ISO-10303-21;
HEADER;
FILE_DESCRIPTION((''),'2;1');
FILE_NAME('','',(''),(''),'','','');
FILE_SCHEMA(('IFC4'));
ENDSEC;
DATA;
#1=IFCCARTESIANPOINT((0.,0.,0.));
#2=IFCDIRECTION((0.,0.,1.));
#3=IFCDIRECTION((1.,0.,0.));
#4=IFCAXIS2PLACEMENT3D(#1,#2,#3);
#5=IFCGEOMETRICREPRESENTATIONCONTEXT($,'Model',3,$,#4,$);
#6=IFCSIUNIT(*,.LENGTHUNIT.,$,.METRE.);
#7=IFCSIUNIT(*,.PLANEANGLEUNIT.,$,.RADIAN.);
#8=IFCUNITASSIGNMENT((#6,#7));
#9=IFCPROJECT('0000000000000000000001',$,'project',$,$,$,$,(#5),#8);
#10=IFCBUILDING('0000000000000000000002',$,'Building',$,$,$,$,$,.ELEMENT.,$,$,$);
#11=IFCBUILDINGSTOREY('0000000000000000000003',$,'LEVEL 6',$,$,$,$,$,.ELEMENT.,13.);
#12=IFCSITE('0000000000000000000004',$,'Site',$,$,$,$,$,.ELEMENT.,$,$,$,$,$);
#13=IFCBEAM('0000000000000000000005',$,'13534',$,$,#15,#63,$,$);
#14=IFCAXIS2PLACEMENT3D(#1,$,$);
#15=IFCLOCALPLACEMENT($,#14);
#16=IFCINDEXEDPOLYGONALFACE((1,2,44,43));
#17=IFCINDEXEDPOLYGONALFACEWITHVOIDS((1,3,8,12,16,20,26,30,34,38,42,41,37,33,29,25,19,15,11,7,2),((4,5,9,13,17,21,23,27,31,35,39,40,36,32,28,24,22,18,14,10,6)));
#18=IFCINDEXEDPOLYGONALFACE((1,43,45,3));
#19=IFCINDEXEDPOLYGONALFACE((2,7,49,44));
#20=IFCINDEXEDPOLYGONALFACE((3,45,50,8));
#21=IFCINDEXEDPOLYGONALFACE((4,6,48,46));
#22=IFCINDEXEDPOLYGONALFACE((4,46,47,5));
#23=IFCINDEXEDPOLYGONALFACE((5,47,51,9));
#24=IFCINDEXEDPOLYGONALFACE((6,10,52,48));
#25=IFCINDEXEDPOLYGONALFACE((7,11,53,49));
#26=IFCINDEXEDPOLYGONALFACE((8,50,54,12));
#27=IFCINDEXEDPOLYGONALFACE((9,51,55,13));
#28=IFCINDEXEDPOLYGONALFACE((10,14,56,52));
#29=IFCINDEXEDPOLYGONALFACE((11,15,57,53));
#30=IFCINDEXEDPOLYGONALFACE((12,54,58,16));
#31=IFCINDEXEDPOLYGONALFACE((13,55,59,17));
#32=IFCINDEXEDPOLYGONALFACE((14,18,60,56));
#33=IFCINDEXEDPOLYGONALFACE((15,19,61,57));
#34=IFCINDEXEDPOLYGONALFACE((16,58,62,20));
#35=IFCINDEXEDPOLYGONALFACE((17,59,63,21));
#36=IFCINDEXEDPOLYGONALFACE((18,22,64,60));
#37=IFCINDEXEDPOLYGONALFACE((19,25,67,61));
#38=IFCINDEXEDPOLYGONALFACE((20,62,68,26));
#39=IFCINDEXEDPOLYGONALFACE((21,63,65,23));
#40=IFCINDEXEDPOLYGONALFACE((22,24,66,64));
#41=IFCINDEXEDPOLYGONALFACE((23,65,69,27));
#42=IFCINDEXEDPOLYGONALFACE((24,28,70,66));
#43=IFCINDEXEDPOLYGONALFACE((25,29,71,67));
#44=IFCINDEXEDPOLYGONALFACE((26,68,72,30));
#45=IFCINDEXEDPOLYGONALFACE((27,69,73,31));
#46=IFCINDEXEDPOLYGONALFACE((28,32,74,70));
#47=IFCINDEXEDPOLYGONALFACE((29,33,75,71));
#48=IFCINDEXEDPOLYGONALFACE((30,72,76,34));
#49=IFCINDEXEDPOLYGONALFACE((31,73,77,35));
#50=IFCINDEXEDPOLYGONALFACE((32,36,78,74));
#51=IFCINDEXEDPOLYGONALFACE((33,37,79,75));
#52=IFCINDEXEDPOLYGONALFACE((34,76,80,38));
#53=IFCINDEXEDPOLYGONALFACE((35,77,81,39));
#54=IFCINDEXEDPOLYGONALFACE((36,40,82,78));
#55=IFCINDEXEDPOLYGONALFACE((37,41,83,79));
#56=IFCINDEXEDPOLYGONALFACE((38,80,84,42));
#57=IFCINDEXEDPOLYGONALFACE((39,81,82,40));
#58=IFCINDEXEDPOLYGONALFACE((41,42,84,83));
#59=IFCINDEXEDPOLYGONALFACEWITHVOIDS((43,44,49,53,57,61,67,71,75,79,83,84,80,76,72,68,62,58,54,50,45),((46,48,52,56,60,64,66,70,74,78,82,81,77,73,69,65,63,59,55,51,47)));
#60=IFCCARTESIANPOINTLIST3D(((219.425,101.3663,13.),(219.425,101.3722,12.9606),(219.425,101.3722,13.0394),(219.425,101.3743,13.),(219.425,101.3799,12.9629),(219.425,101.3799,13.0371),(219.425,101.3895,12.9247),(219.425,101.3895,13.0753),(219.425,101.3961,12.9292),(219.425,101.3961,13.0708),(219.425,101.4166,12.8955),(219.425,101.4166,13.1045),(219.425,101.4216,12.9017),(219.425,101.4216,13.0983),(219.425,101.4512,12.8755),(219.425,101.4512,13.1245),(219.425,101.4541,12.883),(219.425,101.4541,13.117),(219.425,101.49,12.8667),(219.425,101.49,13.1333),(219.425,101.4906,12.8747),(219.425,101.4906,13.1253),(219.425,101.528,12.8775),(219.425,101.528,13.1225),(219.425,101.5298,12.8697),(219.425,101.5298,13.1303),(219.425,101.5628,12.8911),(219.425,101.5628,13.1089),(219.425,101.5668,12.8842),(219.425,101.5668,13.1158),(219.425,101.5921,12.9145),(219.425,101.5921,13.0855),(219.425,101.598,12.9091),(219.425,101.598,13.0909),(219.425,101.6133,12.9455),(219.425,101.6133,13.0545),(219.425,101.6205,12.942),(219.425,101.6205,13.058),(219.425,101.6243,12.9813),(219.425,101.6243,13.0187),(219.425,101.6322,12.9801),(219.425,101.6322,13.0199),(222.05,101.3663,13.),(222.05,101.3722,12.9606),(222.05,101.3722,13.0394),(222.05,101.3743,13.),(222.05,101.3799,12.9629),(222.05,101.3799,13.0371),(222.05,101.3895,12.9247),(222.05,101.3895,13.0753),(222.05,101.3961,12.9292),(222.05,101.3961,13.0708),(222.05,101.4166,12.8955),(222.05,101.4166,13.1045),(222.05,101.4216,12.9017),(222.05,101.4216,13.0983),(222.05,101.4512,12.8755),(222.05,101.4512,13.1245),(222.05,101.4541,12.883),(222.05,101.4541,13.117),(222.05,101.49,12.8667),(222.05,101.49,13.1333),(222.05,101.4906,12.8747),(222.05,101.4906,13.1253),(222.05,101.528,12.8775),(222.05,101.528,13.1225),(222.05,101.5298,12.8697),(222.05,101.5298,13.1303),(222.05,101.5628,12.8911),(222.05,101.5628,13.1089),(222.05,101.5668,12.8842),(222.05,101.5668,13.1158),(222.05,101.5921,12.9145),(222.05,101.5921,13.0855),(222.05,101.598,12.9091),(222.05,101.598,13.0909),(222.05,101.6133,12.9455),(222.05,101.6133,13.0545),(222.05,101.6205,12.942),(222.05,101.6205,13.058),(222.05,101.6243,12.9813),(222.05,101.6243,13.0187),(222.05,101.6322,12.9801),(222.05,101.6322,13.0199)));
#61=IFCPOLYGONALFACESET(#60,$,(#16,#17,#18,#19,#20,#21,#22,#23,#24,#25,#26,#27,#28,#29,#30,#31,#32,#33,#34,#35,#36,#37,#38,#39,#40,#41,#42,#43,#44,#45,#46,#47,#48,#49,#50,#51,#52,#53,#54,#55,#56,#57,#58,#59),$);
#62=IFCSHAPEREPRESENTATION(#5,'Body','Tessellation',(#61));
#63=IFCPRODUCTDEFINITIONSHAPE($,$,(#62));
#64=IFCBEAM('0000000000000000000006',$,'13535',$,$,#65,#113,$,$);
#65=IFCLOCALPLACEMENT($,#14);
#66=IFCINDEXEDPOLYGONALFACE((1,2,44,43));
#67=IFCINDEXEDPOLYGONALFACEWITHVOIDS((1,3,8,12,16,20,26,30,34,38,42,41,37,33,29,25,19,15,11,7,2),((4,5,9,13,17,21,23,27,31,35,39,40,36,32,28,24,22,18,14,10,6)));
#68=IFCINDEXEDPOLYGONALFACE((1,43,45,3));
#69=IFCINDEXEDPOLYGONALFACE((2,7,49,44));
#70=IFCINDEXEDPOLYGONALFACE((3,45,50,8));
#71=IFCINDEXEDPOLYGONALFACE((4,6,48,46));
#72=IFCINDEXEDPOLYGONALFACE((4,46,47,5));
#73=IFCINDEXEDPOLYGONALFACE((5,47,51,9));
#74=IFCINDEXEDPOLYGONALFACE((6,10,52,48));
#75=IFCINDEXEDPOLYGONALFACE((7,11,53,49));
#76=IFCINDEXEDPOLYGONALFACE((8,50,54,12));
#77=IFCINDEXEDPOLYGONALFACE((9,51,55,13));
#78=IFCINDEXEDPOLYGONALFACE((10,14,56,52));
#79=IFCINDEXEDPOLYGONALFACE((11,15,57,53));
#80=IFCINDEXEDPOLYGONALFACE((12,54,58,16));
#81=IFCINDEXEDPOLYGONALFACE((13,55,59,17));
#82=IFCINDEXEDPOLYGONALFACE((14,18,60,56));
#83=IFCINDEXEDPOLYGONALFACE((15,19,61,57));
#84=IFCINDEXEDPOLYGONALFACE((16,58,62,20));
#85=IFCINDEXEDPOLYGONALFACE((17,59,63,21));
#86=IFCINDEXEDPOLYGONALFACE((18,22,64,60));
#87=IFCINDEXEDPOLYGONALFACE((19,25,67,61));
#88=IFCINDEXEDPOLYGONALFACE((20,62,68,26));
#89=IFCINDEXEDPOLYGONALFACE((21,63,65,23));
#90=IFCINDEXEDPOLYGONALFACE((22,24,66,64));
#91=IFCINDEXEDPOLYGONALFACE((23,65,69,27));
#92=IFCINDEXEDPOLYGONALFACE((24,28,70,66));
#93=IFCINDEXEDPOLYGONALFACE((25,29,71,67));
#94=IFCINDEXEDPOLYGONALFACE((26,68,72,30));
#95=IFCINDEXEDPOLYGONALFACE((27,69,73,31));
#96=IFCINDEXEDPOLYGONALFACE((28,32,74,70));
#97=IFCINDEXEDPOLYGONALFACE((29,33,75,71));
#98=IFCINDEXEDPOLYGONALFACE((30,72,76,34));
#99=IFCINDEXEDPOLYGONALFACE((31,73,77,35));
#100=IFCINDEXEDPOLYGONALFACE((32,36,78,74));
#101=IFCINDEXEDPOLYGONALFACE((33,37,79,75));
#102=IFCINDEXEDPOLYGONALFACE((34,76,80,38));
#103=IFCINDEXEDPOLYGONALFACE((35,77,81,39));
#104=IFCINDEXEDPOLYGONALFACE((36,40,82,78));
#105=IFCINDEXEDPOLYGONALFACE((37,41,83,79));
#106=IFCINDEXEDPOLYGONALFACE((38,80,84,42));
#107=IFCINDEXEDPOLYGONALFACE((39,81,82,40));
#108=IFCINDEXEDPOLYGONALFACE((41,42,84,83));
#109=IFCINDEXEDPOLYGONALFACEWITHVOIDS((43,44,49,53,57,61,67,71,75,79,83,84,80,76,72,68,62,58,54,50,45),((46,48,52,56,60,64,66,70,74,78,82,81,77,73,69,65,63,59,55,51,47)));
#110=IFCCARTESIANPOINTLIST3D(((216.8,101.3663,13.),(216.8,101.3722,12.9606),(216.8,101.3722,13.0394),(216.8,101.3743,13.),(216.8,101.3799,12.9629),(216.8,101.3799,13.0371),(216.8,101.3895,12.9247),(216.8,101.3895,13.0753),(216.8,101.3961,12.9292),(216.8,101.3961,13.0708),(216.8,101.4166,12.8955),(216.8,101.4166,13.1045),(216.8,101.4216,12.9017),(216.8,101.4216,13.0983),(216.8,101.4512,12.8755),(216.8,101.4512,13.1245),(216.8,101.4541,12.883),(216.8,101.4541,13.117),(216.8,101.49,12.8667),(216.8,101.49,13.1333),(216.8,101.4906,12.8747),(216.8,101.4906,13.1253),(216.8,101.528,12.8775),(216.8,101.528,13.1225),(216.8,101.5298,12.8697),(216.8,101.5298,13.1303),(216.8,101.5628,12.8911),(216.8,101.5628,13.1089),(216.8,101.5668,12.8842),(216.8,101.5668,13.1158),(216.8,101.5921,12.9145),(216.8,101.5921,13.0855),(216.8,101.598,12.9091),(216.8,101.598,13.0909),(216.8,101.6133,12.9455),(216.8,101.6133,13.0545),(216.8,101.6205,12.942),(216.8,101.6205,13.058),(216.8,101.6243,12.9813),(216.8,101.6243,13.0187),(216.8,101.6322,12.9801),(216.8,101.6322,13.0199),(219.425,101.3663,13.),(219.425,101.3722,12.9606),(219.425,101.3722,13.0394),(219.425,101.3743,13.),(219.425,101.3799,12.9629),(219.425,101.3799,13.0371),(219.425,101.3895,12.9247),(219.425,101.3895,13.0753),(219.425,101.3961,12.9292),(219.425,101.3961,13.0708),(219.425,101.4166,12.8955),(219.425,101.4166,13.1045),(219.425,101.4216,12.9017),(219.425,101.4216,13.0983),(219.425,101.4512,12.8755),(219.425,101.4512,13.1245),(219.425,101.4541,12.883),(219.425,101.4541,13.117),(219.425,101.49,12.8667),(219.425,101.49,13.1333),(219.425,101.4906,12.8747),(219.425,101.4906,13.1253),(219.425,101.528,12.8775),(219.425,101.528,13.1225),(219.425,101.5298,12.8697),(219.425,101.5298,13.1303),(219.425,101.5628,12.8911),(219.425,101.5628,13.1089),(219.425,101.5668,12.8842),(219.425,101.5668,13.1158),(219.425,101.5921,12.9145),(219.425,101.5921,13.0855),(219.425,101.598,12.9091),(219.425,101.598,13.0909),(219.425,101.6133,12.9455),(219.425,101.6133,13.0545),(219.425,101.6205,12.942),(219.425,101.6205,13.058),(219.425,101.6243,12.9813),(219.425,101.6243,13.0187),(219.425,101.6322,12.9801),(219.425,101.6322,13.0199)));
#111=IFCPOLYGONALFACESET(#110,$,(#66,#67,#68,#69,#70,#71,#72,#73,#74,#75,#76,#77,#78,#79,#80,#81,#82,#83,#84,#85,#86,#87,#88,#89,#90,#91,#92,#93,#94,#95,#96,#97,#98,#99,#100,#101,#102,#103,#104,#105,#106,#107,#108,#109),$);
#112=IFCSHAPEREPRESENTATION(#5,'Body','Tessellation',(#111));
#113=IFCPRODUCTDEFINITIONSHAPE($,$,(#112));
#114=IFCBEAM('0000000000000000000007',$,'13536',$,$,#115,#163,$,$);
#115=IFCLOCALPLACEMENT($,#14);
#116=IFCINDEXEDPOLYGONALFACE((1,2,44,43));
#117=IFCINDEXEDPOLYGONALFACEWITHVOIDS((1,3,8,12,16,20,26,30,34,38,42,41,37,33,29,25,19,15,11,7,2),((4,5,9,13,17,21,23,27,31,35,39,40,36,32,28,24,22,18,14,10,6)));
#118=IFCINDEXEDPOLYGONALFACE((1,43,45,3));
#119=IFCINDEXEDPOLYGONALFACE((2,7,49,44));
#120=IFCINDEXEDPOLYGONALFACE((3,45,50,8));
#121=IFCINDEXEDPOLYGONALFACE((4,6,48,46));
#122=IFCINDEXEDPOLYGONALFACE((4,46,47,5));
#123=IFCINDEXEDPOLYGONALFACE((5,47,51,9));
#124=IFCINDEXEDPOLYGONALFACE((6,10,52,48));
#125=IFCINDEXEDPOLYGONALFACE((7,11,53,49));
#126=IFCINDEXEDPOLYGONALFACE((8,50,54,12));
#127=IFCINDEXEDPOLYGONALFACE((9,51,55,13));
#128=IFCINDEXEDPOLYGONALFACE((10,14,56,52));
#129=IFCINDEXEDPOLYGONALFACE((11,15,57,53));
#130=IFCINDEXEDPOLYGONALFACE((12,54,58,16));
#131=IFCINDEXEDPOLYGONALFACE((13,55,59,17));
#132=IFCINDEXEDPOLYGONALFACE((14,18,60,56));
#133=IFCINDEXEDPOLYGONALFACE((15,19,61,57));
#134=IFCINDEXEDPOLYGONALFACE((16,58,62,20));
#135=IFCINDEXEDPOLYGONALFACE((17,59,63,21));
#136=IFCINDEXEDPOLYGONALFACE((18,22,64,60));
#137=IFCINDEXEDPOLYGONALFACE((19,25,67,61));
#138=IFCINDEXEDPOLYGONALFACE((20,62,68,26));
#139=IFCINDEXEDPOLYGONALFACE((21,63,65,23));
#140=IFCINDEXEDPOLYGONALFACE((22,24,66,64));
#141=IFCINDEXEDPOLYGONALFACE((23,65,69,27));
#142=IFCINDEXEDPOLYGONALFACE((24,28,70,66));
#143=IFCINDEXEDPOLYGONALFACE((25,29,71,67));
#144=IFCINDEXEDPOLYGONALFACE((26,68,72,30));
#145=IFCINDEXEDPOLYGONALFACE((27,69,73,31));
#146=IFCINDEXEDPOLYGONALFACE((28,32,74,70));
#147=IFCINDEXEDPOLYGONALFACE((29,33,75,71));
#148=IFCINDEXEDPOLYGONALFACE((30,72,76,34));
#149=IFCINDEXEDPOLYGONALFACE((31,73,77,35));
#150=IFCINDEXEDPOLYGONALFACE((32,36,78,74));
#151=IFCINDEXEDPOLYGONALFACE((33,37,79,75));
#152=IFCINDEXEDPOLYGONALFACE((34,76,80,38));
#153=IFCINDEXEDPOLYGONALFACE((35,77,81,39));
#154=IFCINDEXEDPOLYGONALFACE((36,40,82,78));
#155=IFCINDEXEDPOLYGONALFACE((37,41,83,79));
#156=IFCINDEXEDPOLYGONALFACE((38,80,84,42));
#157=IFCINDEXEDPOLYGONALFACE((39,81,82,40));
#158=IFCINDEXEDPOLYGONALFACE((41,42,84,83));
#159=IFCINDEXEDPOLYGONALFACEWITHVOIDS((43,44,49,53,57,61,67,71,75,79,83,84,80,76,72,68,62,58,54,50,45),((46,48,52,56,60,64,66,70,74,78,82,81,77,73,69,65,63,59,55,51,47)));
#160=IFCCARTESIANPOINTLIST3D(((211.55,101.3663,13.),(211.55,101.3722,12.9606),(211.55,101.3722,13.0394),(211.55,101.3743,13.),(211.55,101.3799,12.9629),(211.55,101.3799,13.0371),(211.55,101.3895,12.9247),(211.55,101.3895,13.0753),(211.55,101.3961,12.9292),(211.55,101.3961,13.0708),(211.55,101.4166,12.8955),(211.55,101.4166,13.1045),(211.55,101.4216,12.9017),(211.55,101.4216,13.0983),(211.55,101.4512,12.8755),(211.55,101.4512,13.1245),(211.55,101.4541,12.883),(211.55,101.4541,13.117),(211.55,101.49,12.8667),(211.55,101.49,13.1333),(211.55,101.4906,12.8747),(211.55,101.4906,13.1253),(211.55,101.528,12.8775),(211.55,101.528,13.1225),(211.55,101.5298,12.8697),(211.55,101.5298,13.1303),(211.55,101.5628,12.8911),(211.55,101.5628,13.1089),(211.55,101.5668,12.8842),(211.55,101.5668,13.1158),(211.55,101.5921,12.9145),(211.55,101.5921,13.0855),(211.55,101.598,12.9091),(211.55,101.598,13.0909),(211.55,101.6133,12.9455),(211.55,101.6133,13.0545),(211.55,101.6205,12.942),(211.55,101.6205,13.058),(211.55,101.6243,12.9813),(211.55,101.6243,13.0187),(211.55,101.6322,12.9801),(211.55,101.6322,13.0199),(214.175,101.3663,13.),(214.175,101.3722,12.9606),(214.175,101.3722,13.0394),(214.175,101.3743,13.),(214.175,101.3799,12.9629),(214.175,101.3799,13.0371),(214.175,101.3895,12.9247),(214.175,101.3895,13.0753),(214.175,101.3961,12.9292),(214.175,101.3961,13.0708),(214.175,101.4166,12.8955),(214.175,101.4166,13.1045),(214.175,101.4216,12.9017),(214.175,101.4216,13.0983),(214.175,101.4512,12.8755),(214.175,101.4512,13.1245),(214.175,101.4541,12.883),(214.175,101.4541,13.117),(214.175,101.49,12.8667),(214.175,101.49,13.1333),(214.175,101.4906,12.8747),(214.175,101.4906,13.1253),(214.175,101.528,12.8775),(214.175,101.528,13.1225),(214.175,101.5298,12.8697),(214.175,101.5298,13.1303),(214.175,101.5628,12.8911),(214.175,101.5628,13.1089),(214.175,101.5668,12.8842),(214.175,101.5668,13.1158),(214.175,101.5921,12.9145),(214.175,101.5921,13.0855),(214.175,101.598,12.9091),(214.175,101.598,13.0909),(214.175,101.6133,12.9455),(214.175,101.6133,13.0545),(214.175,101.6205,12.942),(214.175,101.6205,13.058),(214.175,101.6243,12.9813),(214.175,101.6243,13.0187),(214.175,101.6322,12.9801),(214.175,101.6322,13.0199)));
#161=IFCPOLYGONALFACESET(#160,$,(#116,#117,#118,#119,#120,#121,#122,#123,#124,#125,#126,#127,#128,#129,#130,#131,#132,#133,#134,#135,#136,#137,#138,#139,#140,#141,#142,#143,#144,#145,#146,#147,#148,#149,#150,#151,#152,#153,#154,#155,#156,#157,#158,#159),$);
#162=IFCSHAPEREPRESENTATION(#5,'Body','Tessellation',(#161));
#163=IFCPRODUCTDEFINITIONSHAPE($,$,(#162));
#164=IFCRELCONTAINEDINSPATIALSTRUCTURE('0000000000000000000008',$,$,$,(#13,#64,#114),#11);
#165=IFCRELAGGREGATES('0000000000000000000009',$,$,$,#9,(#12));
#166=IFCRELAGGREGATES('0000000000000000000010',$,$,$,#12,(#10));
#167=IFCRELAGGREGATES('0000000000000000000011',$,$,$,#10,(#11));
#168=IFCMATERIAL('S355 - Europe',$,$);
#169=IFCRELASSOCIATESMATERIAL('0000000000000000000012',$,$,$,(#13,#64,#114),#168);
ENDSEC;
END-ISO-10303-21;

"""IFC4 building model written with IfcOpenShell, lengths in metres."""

from ifc_helpers import new_model, si_unit, frame, origin_with_axes, origin_2d_with_axis, place, context, project, spatial, hollow_circle, extrude, material, material_profile, profile_set, profile_usage, element, save


model = new_model("IFC4")

# Units and contexts
model_context = context("Model", 3, world=origin_with_axes())
ifc_project = project(units=[si_unit("LENGTHUNIT", "METRE"), si_unit("PLANEANGLEUNIT", "RADIAN")], contexts=[model_context])

# Site, building, storey
site = spatial("IfcSite", under=ifc_project, Name="Site", CompositionType="ELEMENT")
building = spatial("IfcBuilding", under=site, Name="Building", CompositionType="ELEMENT")
storey = spatial("IfcBuildingStorey", under=building, Name="LEVEL 6", CompositionType="ELEMENT", Elevation=13.0)

# Shared definitions
ifc_material = material(Name="S355 - Europe")

# Beams
ifc_material_profile_1 = material_profile(ifc_material, hollow_circle(Radius=0.1337, WallThickness=0.008, at=origin_2d_with_axis()))
ifc_profile_set_1 = profile_set([ifc_material_profile_1])
ifc_profile_usage_1 = profile_usage(ifc_profile_set_1, cardinal=10)
beam_1_placement = place(None, frame((222.05, 101.5, 13.0), z_axis=(-1.0, 0.0, 0.0), x_axis=(0.0, -1.0, 0.0)))
element("IfcBeam", 1, at=beam_1_placement, inside=storey, material=ifc_profile_usage_1, Name="13534", context=model_context, shape_type="SweptSolid", body=[
    extrude(hollow_circle(Radius=0.1337, WallThickness=0.008, at=origin_2d_with_axis()), origin_with_axes(), (0.0, 0.0, 1.0), 2.625),
])
ifc_material_profile_2 = material_profile(ifc_material, hollow_circle(Radius=0.1337, WallThickness=0.008, at=origin_2d_with_axis()))
ifc_profile_set_2 = profile_set([ifc_material_profile_2])
ifc_profile_usage_2 = profile_usage(ifc_profile_set_2, cardinal=10)
beam_2_placement = place(None, frame((219.425, 101.5, 13.0), z_axis=(-1.0, 0.0, 0.0), x_axis=(0.0, -1.0, 0.0)))
element("IfcBeam", 2, at=beam_2_placement, inside=storey, material=ifc_profile_usage_2, Name="13535", context=model_context, shape_type="SweptSolid", body=[
    extrude(hollow_circle(Radius=0.1337, WallThickness=0.008, at=origin_2d_with_axis()), origin_with_axes(), (0.0, 0.0, 1.0), 2.625),
])
ifc_material_profile_3 = material_profile(ifc_material, hollow_circle(Radius=0.1337, WallThickness=0.008, at=origin_2d_with_axis()))
ifc_profile_set_3 = profile_set([ifc_material_profile_3])
ifc_profile_usage_3 = profile_usage(ifc_profile_set_3, cardinal=10)
beam_3_placement = place(None, frame((214.175, 101.5, 13.0), z_axis=(-1.0, 0.0, 0.0), x_axis=(0.0, -1.0, 0.0)))
element("IfcBeam", 3, at=beam_3_placement, inside=storey, material=ifc_profile_usage_3, Name="13536", context=model_context, shape_type="SweptSolid", body=[
    extrude(hollow_circle(Radius=0.1337, WallThickness=0.008, at=origin_2d_with_axis()), origin_with_axes(), (0.0, 0.0, 1.0), 2.625),
])

save(model, "model.ifc")
